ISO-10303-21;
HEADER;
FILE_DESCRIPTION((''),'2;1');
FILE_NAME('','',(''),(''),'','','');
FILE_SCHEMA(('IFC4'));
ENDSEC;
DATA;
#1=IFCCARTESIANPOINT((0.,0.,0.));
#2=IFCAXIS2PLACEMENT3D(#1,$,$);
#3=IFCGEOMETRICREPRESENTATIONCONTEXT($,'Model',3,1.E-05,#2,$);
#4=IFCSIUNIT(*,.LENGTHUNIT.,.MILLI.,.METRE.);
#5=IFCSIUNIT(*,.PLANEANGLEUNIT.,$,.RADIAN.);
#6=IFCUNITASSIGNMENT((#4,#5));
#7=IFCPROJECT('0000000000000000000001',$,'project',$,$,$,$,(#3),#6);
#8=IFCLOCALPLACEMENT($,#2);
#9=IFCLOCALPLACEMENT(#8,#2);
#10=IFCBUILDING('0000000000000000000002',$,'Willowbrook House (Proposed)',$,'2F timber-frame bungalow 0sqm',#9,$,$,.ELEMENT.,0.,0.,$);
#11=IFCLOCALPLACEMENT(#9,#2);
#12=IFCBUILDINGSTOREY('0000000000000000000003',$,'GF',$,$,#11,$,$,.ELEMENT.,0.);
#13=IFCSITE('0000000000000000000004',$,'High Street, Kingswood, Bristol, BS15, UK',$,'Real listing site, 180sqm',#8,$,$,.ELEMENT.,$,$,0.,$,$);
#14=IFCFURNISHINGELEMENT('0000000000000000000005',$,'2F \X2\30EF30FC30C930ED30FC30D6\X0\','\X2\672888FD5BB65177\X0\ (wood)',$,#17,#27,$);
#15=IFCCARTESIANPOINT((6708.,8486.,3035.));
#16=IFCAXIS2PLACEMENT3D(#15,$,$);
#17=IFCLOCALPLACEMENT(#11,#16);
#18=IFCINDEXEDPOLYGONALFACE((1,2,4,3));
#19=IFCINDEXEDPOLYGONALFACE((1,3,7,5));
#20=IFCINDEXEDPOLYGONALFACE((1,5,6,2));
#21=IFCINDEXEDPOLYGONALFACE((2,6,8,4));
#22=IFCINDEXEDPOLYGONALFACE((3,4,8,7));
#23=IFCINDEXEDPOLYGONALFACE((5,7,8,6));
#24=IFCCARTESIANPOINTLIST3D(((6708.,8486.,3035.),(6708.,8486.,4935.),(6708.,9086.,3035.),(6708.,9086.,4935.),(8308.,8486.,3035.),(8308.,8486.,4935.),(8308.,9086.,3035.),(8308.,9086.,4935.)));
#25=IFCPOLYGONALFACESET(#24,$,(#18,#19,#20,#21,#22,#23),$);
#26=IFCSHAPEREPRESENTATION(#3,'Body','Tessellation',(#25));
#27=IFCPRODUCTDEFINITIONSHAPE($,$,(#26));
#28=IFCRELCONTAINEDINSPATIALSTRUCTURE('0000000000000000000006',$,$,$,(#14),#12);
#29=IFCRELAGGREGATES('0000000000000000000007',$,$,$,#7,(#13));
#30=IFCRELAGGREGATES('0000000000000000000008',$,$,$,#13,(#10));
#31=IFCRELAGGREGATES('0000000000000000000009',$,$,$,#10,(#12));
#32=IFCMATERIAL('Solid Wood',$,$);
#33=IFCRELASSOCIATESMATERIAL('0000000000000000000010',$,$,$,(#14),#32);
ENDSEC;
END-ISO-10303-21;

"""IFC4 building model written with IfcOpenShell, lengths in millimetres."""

from ifc_helpers import new_model, si_unit, frame, frame_2d, origin, place, context, project, spatial, rectangle, extrude, material, element, save


model = new_model("IFC4")

# Units and contexts
model_context = context("Model", 3, precision=1e-05, world=origin())
ifc_project = project(units=[si_unit("LENGTHUNIT", "METRE", prefix="MILLI"), si_unit("PLANEANGLEUNIT", "RADIAN")], contexts=[model_context])

# Site, building, storey
site_placement = place(None, origin())
site = spatial("IfcSite", under=ifc_project, at=site_placement, Name="High Street, Kingswood, Bristol, BS15, UK", ObjectType="Real listing site, 180sqm", CompositionType="ELEMENT", RefElevation=0.0)
building_placement = place(site_placement, origin())
building = spatial("IfcBuilding", under=site, at=building_placement, Name="Willowbrook House (Proposed)", ObjectType="2F timber-frame bungalow 0sqm", CompositionType="ELEMENT", ElevationOfRefHeight=0.0, ElevationOfTerrain=0.0)
storey_placement = place(building_placement, origin())
storey = spatial("IfcBuildingStorey", under=building, at=storey_placement, Name="GF", CompositionType="ELEMENT", Elevation=0.0)

# Shared definitions
ifc_material_1 = material(Name="Solid Wood")

# Furnishing element
furnishing_1_placement = place(storey_placement, frame((6708.0, 8486.0, 3035.0)))
element("IfcFurnishingElement", 1, at=furnishing_1_placement, inside=storey, material=ifc_material_1, Name="2F ワードローブ", Description="木製家具 (wood)", context=model_context, shape_type="SweptSolid", body=[
    extrude(rectangle(XDim=1600.0, YDim=600.0, at=frame_2d((800.0, 300.0))), frame((6708.0, 8486.0, 3035.0)), (0.0, 0.0, 1.0), 1900.0),
])

save(model, "model.ifc")
